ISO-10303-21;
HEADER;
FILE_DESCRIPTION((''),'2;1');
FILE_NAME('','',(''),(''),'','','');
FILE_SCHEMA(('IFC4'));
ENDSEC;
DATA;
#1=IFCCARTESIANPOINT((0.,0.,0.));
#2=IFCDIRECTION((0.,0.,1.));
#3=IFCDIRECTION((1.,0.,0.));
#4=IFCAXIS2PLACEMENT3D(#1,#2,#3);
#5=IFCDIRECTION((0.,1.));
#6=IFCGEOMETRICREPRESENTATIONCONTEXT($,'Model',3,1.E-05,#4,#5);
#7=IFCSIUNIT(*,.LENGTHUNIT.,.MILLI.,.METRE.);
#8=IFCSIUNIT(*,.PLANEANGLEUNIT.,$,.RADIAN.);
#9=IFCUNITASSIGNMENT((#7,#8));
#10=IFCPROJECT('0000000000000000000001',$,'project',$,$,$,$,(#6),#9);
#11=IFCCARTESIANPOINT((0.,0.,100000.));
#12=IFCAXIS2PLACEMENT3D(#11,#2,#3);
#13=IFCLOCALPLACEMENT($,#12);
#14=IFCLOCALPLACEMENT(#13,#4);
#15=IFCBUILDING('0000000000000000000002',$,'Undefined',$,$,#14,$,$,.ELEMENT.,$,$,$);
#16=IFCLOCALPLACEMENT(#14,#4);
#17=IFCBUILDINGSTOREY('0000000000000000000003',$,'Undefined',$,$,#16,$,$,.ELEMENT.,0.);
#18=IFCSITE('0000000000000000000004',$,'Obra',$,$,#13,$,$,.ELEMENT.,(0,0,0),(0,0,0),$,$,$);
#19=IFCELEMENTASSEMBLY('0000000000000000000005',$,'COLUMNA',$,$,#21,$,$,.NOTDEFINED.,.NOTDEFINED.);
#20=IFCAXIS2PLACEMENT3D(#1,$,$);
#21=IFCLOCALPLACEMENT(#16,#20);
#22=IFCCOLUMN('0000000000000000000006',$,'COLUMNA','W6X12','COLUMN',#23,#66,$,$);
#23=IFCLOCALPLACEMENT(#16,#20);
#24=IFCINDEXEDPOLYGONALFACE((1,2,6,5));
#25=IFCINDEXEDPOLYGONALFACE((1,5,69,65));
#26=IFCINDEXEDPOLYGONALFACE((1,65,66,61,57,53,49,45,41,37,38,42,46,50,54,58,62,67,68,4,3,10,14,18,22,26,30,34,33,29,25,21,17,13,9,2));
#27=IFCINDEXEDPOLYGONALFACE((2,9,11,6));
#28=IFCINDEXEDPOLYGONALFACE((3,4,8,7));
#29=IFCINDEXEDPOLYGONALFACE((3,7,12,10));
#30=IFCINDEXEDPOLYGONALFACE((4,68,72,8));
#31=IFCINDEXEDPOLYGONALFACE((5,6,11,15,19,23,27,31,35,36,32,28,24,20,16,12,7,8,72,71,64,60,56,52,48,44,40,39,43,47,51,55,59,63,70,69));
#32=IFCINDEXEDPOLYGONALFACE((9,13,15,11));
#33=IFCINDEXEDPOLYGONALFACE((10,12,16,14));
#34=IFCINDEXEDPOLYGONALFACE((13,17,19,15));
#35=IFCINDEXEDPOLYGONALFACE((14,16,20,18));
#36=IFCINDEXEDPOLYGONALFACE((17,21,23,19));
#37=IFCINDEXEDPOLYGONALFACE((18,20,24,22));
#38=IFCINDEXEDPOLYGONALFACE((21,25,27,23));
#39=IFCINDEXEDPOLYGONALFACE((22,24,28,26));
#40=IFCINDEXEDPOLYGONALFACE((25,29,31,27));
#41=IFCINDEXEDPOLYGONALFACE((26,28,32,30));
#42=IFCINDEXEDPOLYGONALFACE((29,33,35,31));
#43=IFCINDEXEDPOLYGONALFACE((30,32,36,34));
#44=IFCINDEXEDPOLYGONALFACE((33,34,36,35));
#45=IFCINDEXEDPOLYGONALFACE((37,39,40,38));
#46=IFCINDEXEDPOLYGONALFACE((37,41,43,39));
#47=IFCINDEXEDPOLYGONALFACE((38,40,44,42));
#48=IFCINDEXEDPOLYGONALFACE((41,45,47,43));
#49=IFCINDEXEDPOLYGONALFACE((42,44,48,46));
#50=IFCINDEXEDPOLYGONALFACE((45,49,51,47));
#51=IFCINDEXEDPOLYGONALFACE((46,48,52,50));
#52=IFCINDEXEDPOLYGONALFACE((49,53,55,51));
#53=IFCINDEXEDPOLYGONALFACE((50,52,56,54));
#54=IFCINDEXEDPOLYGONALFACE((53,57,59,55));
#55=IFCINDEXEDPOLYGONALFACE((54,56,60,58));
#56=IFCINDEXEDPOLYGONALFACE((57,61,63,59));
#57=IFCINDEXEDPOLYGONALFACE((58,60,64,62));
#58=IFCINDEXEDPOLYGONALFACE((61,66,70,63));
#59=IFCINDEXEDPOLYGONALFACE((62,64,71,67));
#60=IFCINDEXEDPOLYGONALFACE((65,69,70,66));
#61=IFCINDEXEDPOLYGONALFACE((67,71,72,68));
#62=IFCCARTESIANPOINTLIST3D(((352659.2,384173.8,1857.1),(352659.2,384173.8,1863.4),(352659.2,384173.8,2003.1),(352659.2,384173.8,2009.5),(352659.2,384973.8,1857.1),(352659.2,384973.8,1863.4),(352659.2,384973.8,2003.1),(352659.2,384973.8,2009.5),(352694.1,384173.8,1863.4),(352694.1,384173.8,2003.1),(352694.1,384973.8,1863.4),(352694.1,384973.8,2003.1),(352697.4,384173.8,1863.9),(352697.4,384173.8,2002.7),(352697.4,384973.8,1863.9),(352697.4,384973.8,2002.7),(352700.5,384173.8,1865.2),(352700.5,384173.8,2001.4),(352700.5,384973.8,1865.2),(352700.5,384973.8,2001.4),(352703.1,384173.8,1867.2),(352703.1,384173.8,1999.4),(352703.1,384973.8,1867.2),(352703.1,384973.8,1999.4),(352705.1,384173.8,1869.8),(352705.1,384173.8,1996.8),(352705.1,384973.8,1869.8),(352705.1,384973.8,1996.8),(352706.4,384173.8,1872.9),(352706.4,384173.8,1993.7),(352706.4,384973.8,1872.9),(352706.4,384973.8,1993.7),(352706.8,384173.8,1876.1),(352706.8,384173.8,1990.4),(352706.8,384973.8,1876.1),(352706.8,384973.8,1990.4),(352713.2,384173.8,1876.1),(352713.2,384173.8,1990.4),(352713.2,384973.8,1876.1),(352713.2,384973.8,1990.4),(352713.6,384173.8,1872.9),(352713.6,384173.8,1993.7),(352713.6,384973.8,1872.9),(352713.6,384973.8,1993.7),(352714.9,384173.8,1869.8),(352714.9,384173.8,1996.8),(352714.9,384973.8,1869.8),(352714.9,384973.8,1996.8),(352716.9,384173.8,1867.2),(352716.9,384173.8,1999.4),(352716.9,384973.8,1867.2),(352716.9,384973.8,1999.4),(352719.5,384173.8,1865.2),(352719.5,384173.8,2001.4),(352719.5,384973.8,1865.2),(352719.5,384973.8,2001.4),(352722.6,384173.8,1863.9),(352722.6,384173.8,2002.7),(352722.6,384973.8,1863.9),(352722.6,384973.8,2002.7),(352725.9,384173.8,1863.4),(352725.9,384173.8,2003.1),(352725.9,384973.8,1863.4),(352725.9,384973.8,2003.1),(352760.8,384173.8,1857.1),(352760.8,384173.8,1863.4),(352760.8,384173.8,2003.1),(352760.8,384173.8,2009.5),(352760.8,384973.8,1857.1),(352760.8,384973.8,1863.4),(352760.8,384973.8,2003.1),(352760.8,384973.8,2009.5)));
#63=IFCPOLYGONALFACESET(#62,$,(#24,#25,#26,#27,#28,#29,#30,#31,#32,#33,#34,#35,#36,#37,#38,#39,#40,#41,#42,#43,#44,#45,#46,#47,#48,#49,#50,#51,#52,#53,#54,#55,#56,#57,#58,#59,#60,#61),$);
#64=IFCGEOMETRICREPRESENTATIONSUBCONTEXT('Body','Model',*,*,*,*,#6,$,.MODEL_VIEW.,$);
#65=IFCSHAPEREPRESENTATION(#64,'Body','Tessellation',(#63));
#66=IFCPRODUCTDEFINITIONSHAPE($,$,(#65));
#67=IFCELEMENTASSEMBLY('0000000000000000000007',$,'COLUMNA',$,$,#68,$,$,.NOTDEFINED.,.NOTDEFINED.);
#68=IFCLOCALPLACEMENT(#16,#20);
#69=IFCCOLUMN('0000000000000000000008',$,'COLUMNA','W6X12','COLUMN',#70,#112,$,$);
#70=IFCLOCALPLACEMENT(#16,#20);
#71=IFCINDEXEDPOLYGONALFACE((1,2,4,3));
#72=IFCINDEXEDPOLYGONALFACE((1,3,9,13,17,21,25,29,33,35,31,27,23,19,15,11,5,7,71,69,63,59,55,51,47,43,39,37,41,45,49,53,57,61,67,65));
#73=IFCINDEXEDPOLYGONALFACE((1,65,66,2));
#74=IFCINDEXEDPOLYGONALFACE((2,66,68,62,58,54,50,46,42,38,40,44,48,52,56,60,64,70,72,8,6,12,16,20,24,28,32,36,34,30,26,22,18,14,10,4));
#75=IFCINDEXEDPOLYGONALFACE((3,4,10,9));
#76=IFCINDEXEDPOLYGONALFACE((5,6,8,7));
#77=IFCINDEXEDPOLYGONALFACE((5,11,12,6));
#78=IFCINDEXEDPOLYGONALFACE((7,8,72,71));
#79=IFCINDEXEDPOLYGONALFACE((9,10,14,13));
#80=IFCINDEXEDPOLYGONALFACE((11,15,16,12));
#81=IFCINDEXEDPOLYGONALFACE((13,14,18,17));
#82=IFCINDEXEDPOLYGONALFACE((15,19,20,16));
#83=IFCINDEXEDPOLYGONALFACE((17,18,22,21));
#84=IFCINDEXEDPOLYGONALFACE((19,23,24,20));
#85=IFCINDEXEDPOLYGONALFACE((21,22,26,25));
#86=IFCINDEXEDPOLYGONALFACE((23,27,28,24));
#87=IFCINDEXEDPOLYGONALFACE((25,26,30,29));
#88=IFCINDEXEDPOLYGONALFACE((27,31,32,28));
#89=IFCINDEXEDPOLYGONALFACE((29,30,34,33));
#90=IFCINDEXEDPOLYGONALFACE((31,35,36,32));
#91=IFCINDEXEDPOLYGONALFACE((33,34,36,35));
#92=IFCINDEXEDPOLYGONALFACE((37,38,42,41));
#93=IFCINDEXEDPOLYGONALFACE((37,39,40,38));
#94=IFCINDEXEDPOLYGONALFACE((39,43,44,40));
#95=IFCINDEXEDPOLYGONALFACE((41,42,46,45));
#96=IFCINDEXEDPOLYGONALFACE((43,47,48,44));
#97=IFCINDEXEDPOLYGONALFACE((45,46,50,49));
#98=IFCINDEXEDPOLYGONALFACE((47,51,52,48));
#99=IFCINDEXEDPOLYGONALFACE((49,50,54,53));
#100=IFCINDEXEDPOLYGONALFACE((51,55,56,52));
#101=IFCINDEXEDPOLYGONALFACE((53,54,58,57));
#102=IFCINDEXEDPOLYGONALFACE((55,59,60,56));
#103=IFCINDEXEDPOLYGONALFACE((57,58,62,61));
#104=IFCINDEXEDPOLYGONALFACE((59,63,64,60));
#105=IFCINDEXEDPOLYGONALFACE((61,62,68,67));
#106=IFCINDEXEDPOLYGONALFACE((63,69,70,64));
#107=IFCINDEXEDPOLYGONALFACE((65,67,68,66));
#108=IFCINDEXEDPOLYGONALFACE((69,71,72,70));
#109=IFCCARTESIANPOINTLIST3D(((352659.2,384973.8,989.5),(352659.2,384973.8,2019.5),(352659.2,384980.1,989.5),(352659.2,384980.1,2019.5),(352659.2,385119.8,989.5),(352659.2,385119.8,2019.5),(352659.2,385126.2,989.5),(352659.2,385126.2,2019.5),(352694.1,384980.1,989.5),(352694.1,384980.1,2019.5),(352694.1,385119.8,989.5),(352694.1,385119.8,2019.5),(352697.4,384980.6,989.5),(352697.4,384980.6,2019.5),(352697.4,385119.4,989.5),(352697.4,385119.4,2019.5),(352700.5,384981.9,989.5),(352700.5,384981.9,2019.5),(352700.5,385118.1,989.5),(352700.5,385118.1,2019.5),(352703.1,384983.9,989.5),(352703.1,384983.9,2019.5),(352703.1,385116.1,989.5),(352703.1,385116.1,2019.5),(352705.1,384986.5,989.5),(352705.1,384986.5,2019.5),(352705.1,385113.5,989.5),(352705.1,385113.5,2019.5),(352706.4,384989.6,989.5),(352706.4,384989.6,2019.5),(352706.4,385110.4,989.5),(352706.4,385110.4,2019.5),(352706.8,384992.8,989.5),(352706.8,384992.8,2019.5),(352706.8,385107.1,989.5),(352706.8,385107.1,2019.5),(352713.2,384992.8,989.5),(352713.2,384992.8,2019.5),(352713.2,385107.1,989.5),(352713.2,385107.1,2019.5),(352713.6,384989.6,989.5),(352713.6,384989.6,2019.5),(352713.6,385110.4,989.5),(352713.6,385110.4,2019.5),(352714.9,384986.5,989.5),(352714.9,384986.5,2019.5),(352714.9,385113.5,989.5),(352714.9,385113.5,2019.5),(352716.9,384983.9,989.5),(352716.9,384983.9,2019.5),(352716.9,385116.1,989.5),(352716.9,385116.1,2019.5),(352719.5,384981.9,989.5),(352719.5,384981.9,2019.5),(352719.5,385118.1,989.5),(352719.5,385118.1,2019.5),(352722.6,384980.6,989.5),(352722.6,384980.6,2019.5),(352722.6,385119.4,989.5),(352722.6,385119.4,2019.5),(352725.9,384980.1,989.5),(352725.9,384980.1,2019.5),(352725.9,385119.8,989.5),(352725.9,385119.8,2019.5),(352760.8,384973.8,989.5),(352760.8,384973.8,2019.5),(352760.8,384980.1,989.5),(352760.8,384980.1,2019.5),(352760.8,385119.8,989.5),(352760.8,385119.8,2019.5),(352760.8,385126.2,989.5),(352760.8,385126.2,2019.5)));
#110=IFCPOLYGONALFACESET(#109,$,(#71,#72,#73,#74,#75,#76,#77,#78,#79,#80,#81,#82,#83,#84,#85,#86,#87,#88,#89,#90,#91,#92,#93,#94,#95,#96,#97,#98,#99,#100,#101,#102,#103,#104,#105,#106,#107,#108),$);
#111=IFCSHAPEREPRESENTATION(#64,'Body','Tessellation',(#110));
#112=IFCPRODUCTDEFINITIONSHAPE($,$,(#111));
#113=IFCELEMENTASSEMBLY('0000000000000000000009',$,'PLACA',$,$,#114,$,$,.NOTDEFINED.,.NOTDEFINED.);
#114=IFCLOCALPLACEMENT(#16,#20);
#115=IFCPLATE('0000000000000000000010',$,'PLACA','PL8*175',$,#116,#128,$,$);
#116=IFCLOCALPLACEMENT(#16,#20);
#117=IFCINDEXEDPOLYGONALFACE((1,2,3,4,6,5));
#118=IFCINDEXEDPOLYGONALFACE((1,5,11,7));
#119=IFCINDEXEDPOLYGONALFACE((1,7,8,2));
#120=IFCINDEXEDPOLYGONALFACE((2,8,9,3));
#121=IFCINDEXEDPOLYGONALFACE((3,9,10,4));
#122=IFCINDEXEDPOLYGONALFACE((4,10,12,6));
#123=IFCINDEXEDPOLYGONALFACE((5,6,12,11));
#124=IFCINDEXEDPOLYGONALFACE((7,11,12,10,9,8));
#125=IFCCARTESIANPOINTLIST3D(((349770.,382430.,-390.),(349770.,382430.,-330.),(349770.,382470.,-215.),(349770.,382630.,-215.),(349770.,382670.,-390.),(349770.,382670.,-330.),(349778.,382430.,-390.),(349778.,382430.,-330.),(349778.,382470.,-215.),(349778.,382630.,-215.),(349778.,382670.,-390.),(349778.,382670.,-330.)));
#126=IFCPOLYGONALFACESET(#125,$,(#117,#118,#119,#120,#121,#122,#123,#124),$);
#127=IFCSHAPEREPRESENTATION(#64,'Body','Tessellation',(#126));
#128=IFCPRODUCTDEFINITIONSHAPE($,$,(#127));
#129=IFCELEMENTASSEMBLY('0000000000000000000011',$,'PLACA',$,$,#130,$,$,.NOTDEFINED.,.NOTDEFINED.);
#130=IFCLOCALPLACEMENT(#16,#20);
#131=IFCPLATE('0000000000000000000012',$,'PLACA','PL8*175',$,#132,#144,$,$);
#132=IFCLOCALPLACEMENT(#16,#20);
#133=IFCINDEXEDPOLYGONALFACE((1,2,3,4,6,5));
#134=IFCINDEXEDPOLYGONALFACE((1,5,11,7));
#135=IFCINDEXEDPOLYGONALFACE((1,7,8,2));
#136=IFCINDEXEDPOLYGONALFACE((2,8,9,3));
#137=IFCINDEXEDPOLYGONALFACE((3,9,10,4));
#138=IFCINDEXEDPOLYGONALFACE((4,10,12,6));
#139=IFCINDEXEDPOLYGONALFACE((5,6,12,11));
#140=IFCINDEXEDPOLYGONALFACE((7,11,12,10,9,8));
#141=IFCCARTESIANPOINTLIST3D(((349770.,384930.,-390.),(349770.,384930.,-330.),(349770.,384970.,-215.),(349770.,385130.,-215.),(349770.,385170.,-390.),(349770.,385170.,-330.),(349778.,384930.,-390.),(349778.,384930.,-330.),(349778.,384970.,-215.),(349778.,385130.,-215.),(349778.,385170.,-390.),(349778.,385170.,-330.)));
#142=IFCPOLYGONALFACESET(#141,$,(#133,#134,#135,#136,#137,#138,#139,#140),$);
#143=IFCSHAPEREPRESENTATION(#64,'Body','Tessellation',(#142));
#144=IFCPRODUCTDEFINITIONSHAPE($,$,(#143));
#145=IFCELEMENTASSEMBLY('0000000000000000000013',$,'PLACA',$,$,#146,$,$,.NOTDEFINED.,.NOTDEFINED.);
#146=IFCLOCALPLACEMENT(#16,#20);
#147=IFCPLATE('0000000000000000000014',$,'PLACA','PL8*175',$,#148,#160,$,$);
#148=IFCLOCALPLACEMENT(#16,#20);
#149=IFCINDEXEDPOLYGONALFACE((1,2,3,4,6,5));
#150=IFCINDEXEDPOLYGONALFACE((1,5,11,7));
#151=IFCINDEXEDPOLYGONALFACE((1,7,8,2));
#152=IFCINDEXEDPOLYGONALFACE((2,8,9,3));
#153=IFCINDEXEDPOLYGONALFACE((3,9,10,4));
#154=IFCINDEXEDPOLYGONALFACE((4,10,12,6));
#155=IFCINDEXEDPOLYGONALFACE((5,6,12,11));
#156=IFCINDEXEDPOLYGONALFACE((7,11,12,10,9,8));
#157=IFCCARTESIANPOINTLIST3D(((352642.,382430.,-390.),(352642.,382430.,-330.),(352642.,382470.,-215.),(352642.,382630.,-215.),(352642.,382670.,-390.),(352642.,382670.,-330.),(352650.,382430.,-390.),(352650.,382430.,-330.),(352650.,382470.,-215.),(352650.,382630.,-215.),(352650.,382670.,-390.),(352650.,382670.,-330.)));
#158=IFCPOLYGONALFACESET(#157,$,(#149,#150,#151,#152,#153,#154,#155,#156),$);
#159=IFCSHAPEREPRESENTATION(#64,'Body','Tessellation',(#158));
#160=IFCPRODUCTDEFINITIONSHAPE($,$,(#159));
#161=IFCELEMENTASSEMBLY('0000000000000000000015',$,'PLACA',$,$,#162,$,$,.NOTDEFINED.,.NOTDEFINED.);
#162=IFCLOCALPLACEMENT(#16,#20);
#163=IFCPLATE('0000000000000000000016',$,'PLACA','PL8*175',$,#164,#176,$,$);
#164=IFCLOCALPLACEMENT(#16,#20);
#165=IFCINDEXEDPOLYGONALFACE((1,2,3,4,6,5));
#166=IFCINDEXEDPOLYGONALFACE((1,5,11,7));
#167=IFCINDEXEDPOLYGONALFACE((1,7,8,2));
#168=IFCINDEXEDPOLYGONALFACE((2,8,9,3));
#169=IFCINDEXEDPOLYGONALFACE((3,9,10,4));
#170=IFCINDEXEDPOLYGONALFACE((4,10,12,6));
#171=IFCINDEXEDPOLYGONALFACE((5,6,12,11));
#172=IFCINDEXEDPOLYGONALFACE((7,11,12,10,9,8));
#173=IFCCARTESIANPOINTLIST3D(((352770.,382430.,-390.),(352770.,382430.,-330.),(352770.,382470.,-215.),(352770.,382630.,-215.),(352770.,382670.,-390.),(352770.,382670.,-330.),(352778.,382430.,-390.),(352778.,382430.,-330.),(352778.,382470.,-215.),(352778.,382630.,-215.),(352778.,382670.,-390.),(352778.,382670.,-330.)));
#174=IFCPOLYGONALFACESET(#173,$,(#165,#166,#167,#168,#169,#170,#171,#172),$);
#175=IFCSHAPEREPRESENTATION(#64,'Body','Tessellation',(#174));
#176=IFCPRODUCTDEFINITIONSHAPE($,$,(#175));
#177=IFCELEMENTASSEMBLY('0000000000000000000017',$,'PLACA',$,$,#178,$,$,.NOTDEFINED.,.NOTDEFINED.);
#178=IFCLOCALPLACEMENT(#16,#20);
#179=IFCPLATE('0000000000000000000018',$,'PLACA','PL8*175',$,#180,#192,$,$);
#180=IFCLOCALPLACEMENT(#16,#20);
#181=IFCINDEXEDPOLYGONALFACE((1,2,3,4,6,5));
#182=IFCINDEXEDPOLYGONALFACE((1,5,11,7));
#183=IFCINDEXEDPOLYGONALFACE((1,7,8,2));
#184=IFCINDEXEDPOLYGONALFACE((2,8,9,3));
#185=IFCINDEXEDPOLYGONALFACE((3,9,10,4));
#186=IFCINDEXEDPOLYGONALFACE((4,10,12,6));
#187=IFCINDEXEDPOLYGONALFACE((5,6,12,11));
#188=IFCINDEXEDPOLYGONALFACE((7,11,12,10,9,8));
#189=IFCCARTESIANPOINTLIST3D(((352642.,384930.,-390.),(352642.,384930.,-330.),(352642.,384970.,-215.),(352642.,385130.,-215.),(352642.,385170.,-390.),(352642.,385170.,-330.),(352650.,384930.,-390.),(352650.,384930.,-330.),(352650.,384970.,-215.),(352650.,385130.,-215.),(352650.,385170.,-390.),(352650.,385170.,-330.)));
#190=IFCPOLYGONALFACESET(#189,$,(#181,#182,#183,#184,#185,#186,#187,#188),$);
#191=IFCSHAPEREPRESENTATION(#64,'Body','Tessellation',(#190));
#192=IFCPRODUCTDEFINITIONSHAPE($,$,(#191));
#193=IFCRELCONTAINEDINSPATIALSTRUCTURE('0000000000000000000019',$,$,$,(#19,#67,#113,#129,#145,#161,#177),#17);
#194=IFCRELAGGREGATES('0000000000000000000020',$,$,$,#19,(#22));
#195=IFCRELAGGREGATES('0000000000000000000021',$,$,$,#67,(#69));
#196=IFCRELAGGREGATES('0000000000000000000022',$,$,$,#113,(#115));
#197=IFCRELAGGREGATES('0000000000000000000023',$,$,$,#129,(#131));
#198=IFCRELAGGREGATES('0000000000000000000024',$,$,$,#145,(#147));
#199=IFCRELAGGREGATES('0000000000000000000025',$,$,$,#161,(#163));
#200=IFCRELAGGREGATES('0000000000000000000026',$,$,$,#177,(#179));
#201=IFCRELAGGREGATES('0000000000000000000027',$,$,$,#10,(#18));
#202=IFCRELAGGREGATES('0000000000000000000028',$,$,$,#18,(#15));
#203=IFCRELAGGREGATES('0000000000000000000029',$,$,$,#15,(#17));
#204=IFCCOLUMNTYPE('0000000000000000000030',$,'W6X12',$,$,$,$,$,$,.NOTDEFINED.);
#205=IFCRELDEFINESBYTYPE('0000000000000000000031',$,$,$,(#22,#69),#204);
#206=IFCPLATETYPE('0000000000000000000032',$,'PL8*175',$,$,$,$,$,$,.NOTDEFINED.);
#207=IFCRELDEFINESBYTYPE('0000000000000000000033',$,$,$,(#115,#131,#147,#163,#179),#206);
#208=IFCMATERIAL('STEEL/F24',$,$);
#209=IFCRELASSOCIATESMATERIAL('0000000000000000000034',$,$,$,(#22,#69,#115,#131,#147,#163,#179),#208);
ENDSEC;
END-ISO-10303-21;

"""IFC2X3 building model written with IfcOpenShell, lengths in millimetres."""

from ifc_helpers import new_model, si_unit, direction, frame, origin_with_axes, origin_2d_with_axis, place, context, subcontext, project, spatial, polyline, i_section, outline, extrude, material, type_object, element, aggregate, save


model = new_model("IFC2X3")

# Units and contexts
model_context = context("Model", 3, precision=1e-05, world=origin_with_axes(), true_north=direction((0.0, 1.0)))
body_context = subcontext(model_context, "Body", "Model", "MODEL_VIEW")
ifc_project = project(units=[si_unit("LENGTHUNIT", "METRE", prefix="MILLI"), si_unit("PLANEANGLEUNIT", "RADIAN")], contexts=[model_context])

# Site, building, storey
site_placement = place(None, frame((0.0, 0.0, 100000.0), z_axis=(0.0, 0.0, 1.0), x_axis=(1.0, 0.0, 0.0)))
site = spatial("IfcSite", under=ifc_project, at=site_placement, Name="Obra", CompositionType="ELEMENT", RefLatitude=(0, 0, 0), RefLongitude=(0, 0, 0))
building_placement = place(site_placement, origin_with_axes())
building = spatial("IfcBuilding", under=site, at=building_placement, Name="Undefined", CompositionType="ELEMENT")
storey_placement = place(building_placement, origin_with_axes())
storey = spatial("IfcBuildingStorey", under=building, at=storey_placement, Name="Undefined", CompositionType="ELEMENT", Elevation=0.0)

# Element assemblies, columns
ifc_material_1 = material(Name="STEEL/F24")
column_type_1 = type_object("IfcColumnType", Name="W6X12", PredefinedType="NOTDEFINED")
assembly_1_placement = place(storey_placement, origin_with_axes())
assembly_1 = element("IfcElementAssembly", 1, at=assembly_1_placement, inside=storey, Name="COLUMNA", AssemblyPlace="NOTDEFINED", PredefinedType="NOTDEFINED")
column_1_placement = place(assembly_1_placement, frame((352710.0, 384973.8, 1933.3), z_axis=(0.0, -1.0, 0.0), x_axis=(0.0, 0.0, -1.0)))
column_1 = element("IfcColumn", 2, at=column_1_placement, type_object=column_type_1, material=ifc_material_1, Name="COLUMNA", Description="W6X12", ObjectType="COLUMN", context=body_context, shape_type="SweptSolid", body=[
    extrude(i_section(OverallWidth=101.6, OverallDepth=152.4, WebThickness=6.3, FlangeThickness=6.3, FilletRadius=12.7, at=origin_2d_with_axis()), frame((0.0, 0.0, 800.0), z_axis=(0.0, 0.0, -1.0), x_axis=(0.0, 1.0, 0.0)), (0.0, 0.0, 1.0), 800.0),
])
aggregate(assembly_1, [column_1])
assembly_2_placement = place(storey_placement, origin_with_axes())
assembly_2 = element("IfcElementAssembly", 3, at=assembly_2_placement, inside=storey, Name="COLUMNA", AssemblyPlace="NOTDEFINED", PredefinedType="NOTDEFINED")
column_2_placement = place(assembly_2_placement, frame((352710.0, 385050.0, 989.5), z_axis=(0.0, 0.0, 1.0), x_axis=(0.0, 1.0, 0.0)))
column_2 = element("IfcColumn", 4, at=column_2_placement, type_object=column_type_1, material=ifc_material_1, Name="COLUMNA", Description="W6X12", ObjectType="COLUMN", context=body_context, shape_type="SweptSolid", body=[
    extrude(i_section(OverallWidth=101.6, OverallDepth=152.4, WebThickness=6.3, FlangeThickness=6.3, FilletRadius=12.7, at=origin_2d_with_axis()), frame((0.0, 0.0, 1030.0), z_axis=(0.0, 0.0, -1.0), x_axis=(0.0, 1.0, 0.0)), (0.0, 0.0, 1.0), 1030.0),
])
aggregate(assembly_2, [column_2])

# Element assemblies, plates
assembly_3_placement = place(storey_placement, origin_with_axes())
assembly_3 = element("IfcElementAssembly", 5, at=assembly_3_placement, inside=storey, Name="PLACA", AssemblyPlace="NOTDEFINED", PredefinedType="NOTDEFINED")
plate_type_1 = type_object("IfcPlateType", Name="PL8*175", PredefinedType="NOTDEFINED")
plate_1_placement = place(assembly_3_placement, frame((349774.0, 382630.0, -215.0), z_axis=(-1.0, 0.0, 0.0), x_axis=(0.0, 0.328521, -0.944497)))
plate_1 = element("IfcPlate", 6, at=plate_1_placement, type_object=plate_type_1, material=ifc_material_1, Name="PLACA", Description="PL8*175", context=body_context, shape_type="SweptSolid", body=[
    extrude(outline(polyline([(0.0, 0.0), (121.8, 0.0), (178.4, 19.7), (99.6, 246.4), (42.9, 226.7), (-52.6, 151.1), (0.0, 0.0)])), frame((0.0, 0.0, -4.0), z_axis=(0.0, 0.0, 1.0), x_axis=(1.0, 0.0, 0.0)), (0.0, 0.0, 1.0), 8.0),
])
aggregate(assembly_3, [plate_1])
assembly_4_placement = place(storey_placement, origin_with_axes())
assembly_4 = element("IfcElementAssembly", 7, at=assembly_4_placement, inside=storey, Name="PLACA", AssemblyPlace="NOTDEFINED", PredefinedType="NOTDEFINED")
plate_2_placement = place(assembly_4_placement, frame((349774.0, 385130.0, -215.0), z_axis=(-1.0, 0.0, 0.0), x_axis=(0.0, 0.328521, -0.944497)))
plate_2 = element("IfcPlate", 8, at=plate_2_placement, type_object=plate_type_1, material=ifc_material_1, Name="PLACA", Description="PL8*175", context=body_context, shape_type="SweptSolid", body=[
    extrude(outline(polyline([(0.0, 0.0), (121.8, 0.0), (178.4, 19.7), (99.6, 246.4), (42.9, 226.7), (-52.6, 151.1), (0.0, 0.0)])), frame((0.0, 0.0, -4.0), z_axis=(0.0, 0.0, 1.0), x_axis=(1.0, 0.0, 0.0)), (0.0, 0.0, 1.0), 8.0),
])
aggregate(assembly_4, [plate_2])
assembly_5_placement = place(storey_placement, origin_with_axes())
assembly_5 = element("IfcElementAssembly", 9, at=assembly_5_placement, inside=storey, Name="PLACA", AssemblyPlace="NOTDEFINED", PredefinedType="NOTDEFINED")
plate_3_placement = place(assembly_5_placement, frame((352646.0, 382630.0, -215.0), z_axis=(-1.0, 0.0, 0.0), x_axis=(0.0, 0.328521, -0.944497)))
plate_3 = element("IfcPlate", 10, at=plate_3_placement, type_object=plate_type_1, material=ifc_material_1, Name="PLACA", Description="PL8*175", context=body_context, shape_type="SweptSolid", body=[
    extrude(outline(polyline([(0.0, 0.0), (121.8, 0.0), (178.4, 19.7), (99.6, 246.4), (42.9, 226.7), (-52.6, 151.1), (0.0, 0.0)])), frame((0.0, 0.0, -4.0), z_axis=(0.0, 0.0, 1.0), x_axis=(1.0, 0.0, 0.0)), (0.0, 0.0, 1.0), 8.0),
])
aggregate(assembly_5, [plate_3])
assembly_6_placement = place(storey_placement, origin_with_axes())
assembly_6 = element("IfcElementAssembly", 11, at=assembly_6_placement, inside=storey, Name="PLACA", AssemblyPlace="NOTDEFINED", PredefinedType="NOTDEFINED")
plate_4_placement = place(assembly_6_placement, frame((352774.0, 382630.0, -215.0), z_axis=(-1.0, 0.0, 0.0), x_axis=(0.0, 0.328521, -0.944497)))
plate_4 = element("IfcPlate", 12, at=plate_4_placement, type_object=plate_type_1, material=ifc_material_1, Name="PLACA", Description="PL8*175", context=body_context, shape_type="SweptSolid", body=[
    extrude(outline(polyline([(0.0, 0.0), (121.8, 0.0), (178.4, 19.7), (99.6, 246.4), (42.9, 226.7), (-52.6, 151.1), (0.0, 0.0)])), frame((0.0, 0.0, -4.0), z_axis=(0.0, 0.0, 1.0), x_axis=(1.0, 0.0, 0.0)), (0.0, 0.0, 1.0), 8.0),
])
aggregate(assembly_6, [plate_4])
assembly_7_placement = place(storey_placement, origin_with_axes())
assembly_7 = element("IfcElementAssembly", 13, at=assembly_7_placement, inside=storey, Name="PLACA", AssemblyPlace="NOTDEFINED", PredefinedType="NOTDEFINED")
plate_5_placement = place(assembly_7_placement, frame((352646.0, 385130.0, -215.0), z_axis=(-1.0, 0.0, 0.0), x_axis=(0.0, 0.328521, -0.944497)))
plate_5 = element("IfcPlate", 14, at=plate_5_placement, type_object=plate_type_1, material=ifc_material_1, Name="PLACA", Description="PL8*175", context=body_context, shape_type="SweptSolid", body=[
    extrude(outline(polyline([(0.0, 0.0), (121.8, 0.0), (178.4, 19.7), (99.6, 246.4), (42.9, 226.7), (-52.6, 151.1), (0.0, 0.0)])), frame((0.0, 0.0, -4.0), z_axis=(0.0, 0.0, 1.0), x_axis=(1.0, 0.0, 0.0)), (0.0, 0.0, 1.0), 8.0),
])
aggregate(assembly_7, [plate_5])

save(model, "model.ifc")
